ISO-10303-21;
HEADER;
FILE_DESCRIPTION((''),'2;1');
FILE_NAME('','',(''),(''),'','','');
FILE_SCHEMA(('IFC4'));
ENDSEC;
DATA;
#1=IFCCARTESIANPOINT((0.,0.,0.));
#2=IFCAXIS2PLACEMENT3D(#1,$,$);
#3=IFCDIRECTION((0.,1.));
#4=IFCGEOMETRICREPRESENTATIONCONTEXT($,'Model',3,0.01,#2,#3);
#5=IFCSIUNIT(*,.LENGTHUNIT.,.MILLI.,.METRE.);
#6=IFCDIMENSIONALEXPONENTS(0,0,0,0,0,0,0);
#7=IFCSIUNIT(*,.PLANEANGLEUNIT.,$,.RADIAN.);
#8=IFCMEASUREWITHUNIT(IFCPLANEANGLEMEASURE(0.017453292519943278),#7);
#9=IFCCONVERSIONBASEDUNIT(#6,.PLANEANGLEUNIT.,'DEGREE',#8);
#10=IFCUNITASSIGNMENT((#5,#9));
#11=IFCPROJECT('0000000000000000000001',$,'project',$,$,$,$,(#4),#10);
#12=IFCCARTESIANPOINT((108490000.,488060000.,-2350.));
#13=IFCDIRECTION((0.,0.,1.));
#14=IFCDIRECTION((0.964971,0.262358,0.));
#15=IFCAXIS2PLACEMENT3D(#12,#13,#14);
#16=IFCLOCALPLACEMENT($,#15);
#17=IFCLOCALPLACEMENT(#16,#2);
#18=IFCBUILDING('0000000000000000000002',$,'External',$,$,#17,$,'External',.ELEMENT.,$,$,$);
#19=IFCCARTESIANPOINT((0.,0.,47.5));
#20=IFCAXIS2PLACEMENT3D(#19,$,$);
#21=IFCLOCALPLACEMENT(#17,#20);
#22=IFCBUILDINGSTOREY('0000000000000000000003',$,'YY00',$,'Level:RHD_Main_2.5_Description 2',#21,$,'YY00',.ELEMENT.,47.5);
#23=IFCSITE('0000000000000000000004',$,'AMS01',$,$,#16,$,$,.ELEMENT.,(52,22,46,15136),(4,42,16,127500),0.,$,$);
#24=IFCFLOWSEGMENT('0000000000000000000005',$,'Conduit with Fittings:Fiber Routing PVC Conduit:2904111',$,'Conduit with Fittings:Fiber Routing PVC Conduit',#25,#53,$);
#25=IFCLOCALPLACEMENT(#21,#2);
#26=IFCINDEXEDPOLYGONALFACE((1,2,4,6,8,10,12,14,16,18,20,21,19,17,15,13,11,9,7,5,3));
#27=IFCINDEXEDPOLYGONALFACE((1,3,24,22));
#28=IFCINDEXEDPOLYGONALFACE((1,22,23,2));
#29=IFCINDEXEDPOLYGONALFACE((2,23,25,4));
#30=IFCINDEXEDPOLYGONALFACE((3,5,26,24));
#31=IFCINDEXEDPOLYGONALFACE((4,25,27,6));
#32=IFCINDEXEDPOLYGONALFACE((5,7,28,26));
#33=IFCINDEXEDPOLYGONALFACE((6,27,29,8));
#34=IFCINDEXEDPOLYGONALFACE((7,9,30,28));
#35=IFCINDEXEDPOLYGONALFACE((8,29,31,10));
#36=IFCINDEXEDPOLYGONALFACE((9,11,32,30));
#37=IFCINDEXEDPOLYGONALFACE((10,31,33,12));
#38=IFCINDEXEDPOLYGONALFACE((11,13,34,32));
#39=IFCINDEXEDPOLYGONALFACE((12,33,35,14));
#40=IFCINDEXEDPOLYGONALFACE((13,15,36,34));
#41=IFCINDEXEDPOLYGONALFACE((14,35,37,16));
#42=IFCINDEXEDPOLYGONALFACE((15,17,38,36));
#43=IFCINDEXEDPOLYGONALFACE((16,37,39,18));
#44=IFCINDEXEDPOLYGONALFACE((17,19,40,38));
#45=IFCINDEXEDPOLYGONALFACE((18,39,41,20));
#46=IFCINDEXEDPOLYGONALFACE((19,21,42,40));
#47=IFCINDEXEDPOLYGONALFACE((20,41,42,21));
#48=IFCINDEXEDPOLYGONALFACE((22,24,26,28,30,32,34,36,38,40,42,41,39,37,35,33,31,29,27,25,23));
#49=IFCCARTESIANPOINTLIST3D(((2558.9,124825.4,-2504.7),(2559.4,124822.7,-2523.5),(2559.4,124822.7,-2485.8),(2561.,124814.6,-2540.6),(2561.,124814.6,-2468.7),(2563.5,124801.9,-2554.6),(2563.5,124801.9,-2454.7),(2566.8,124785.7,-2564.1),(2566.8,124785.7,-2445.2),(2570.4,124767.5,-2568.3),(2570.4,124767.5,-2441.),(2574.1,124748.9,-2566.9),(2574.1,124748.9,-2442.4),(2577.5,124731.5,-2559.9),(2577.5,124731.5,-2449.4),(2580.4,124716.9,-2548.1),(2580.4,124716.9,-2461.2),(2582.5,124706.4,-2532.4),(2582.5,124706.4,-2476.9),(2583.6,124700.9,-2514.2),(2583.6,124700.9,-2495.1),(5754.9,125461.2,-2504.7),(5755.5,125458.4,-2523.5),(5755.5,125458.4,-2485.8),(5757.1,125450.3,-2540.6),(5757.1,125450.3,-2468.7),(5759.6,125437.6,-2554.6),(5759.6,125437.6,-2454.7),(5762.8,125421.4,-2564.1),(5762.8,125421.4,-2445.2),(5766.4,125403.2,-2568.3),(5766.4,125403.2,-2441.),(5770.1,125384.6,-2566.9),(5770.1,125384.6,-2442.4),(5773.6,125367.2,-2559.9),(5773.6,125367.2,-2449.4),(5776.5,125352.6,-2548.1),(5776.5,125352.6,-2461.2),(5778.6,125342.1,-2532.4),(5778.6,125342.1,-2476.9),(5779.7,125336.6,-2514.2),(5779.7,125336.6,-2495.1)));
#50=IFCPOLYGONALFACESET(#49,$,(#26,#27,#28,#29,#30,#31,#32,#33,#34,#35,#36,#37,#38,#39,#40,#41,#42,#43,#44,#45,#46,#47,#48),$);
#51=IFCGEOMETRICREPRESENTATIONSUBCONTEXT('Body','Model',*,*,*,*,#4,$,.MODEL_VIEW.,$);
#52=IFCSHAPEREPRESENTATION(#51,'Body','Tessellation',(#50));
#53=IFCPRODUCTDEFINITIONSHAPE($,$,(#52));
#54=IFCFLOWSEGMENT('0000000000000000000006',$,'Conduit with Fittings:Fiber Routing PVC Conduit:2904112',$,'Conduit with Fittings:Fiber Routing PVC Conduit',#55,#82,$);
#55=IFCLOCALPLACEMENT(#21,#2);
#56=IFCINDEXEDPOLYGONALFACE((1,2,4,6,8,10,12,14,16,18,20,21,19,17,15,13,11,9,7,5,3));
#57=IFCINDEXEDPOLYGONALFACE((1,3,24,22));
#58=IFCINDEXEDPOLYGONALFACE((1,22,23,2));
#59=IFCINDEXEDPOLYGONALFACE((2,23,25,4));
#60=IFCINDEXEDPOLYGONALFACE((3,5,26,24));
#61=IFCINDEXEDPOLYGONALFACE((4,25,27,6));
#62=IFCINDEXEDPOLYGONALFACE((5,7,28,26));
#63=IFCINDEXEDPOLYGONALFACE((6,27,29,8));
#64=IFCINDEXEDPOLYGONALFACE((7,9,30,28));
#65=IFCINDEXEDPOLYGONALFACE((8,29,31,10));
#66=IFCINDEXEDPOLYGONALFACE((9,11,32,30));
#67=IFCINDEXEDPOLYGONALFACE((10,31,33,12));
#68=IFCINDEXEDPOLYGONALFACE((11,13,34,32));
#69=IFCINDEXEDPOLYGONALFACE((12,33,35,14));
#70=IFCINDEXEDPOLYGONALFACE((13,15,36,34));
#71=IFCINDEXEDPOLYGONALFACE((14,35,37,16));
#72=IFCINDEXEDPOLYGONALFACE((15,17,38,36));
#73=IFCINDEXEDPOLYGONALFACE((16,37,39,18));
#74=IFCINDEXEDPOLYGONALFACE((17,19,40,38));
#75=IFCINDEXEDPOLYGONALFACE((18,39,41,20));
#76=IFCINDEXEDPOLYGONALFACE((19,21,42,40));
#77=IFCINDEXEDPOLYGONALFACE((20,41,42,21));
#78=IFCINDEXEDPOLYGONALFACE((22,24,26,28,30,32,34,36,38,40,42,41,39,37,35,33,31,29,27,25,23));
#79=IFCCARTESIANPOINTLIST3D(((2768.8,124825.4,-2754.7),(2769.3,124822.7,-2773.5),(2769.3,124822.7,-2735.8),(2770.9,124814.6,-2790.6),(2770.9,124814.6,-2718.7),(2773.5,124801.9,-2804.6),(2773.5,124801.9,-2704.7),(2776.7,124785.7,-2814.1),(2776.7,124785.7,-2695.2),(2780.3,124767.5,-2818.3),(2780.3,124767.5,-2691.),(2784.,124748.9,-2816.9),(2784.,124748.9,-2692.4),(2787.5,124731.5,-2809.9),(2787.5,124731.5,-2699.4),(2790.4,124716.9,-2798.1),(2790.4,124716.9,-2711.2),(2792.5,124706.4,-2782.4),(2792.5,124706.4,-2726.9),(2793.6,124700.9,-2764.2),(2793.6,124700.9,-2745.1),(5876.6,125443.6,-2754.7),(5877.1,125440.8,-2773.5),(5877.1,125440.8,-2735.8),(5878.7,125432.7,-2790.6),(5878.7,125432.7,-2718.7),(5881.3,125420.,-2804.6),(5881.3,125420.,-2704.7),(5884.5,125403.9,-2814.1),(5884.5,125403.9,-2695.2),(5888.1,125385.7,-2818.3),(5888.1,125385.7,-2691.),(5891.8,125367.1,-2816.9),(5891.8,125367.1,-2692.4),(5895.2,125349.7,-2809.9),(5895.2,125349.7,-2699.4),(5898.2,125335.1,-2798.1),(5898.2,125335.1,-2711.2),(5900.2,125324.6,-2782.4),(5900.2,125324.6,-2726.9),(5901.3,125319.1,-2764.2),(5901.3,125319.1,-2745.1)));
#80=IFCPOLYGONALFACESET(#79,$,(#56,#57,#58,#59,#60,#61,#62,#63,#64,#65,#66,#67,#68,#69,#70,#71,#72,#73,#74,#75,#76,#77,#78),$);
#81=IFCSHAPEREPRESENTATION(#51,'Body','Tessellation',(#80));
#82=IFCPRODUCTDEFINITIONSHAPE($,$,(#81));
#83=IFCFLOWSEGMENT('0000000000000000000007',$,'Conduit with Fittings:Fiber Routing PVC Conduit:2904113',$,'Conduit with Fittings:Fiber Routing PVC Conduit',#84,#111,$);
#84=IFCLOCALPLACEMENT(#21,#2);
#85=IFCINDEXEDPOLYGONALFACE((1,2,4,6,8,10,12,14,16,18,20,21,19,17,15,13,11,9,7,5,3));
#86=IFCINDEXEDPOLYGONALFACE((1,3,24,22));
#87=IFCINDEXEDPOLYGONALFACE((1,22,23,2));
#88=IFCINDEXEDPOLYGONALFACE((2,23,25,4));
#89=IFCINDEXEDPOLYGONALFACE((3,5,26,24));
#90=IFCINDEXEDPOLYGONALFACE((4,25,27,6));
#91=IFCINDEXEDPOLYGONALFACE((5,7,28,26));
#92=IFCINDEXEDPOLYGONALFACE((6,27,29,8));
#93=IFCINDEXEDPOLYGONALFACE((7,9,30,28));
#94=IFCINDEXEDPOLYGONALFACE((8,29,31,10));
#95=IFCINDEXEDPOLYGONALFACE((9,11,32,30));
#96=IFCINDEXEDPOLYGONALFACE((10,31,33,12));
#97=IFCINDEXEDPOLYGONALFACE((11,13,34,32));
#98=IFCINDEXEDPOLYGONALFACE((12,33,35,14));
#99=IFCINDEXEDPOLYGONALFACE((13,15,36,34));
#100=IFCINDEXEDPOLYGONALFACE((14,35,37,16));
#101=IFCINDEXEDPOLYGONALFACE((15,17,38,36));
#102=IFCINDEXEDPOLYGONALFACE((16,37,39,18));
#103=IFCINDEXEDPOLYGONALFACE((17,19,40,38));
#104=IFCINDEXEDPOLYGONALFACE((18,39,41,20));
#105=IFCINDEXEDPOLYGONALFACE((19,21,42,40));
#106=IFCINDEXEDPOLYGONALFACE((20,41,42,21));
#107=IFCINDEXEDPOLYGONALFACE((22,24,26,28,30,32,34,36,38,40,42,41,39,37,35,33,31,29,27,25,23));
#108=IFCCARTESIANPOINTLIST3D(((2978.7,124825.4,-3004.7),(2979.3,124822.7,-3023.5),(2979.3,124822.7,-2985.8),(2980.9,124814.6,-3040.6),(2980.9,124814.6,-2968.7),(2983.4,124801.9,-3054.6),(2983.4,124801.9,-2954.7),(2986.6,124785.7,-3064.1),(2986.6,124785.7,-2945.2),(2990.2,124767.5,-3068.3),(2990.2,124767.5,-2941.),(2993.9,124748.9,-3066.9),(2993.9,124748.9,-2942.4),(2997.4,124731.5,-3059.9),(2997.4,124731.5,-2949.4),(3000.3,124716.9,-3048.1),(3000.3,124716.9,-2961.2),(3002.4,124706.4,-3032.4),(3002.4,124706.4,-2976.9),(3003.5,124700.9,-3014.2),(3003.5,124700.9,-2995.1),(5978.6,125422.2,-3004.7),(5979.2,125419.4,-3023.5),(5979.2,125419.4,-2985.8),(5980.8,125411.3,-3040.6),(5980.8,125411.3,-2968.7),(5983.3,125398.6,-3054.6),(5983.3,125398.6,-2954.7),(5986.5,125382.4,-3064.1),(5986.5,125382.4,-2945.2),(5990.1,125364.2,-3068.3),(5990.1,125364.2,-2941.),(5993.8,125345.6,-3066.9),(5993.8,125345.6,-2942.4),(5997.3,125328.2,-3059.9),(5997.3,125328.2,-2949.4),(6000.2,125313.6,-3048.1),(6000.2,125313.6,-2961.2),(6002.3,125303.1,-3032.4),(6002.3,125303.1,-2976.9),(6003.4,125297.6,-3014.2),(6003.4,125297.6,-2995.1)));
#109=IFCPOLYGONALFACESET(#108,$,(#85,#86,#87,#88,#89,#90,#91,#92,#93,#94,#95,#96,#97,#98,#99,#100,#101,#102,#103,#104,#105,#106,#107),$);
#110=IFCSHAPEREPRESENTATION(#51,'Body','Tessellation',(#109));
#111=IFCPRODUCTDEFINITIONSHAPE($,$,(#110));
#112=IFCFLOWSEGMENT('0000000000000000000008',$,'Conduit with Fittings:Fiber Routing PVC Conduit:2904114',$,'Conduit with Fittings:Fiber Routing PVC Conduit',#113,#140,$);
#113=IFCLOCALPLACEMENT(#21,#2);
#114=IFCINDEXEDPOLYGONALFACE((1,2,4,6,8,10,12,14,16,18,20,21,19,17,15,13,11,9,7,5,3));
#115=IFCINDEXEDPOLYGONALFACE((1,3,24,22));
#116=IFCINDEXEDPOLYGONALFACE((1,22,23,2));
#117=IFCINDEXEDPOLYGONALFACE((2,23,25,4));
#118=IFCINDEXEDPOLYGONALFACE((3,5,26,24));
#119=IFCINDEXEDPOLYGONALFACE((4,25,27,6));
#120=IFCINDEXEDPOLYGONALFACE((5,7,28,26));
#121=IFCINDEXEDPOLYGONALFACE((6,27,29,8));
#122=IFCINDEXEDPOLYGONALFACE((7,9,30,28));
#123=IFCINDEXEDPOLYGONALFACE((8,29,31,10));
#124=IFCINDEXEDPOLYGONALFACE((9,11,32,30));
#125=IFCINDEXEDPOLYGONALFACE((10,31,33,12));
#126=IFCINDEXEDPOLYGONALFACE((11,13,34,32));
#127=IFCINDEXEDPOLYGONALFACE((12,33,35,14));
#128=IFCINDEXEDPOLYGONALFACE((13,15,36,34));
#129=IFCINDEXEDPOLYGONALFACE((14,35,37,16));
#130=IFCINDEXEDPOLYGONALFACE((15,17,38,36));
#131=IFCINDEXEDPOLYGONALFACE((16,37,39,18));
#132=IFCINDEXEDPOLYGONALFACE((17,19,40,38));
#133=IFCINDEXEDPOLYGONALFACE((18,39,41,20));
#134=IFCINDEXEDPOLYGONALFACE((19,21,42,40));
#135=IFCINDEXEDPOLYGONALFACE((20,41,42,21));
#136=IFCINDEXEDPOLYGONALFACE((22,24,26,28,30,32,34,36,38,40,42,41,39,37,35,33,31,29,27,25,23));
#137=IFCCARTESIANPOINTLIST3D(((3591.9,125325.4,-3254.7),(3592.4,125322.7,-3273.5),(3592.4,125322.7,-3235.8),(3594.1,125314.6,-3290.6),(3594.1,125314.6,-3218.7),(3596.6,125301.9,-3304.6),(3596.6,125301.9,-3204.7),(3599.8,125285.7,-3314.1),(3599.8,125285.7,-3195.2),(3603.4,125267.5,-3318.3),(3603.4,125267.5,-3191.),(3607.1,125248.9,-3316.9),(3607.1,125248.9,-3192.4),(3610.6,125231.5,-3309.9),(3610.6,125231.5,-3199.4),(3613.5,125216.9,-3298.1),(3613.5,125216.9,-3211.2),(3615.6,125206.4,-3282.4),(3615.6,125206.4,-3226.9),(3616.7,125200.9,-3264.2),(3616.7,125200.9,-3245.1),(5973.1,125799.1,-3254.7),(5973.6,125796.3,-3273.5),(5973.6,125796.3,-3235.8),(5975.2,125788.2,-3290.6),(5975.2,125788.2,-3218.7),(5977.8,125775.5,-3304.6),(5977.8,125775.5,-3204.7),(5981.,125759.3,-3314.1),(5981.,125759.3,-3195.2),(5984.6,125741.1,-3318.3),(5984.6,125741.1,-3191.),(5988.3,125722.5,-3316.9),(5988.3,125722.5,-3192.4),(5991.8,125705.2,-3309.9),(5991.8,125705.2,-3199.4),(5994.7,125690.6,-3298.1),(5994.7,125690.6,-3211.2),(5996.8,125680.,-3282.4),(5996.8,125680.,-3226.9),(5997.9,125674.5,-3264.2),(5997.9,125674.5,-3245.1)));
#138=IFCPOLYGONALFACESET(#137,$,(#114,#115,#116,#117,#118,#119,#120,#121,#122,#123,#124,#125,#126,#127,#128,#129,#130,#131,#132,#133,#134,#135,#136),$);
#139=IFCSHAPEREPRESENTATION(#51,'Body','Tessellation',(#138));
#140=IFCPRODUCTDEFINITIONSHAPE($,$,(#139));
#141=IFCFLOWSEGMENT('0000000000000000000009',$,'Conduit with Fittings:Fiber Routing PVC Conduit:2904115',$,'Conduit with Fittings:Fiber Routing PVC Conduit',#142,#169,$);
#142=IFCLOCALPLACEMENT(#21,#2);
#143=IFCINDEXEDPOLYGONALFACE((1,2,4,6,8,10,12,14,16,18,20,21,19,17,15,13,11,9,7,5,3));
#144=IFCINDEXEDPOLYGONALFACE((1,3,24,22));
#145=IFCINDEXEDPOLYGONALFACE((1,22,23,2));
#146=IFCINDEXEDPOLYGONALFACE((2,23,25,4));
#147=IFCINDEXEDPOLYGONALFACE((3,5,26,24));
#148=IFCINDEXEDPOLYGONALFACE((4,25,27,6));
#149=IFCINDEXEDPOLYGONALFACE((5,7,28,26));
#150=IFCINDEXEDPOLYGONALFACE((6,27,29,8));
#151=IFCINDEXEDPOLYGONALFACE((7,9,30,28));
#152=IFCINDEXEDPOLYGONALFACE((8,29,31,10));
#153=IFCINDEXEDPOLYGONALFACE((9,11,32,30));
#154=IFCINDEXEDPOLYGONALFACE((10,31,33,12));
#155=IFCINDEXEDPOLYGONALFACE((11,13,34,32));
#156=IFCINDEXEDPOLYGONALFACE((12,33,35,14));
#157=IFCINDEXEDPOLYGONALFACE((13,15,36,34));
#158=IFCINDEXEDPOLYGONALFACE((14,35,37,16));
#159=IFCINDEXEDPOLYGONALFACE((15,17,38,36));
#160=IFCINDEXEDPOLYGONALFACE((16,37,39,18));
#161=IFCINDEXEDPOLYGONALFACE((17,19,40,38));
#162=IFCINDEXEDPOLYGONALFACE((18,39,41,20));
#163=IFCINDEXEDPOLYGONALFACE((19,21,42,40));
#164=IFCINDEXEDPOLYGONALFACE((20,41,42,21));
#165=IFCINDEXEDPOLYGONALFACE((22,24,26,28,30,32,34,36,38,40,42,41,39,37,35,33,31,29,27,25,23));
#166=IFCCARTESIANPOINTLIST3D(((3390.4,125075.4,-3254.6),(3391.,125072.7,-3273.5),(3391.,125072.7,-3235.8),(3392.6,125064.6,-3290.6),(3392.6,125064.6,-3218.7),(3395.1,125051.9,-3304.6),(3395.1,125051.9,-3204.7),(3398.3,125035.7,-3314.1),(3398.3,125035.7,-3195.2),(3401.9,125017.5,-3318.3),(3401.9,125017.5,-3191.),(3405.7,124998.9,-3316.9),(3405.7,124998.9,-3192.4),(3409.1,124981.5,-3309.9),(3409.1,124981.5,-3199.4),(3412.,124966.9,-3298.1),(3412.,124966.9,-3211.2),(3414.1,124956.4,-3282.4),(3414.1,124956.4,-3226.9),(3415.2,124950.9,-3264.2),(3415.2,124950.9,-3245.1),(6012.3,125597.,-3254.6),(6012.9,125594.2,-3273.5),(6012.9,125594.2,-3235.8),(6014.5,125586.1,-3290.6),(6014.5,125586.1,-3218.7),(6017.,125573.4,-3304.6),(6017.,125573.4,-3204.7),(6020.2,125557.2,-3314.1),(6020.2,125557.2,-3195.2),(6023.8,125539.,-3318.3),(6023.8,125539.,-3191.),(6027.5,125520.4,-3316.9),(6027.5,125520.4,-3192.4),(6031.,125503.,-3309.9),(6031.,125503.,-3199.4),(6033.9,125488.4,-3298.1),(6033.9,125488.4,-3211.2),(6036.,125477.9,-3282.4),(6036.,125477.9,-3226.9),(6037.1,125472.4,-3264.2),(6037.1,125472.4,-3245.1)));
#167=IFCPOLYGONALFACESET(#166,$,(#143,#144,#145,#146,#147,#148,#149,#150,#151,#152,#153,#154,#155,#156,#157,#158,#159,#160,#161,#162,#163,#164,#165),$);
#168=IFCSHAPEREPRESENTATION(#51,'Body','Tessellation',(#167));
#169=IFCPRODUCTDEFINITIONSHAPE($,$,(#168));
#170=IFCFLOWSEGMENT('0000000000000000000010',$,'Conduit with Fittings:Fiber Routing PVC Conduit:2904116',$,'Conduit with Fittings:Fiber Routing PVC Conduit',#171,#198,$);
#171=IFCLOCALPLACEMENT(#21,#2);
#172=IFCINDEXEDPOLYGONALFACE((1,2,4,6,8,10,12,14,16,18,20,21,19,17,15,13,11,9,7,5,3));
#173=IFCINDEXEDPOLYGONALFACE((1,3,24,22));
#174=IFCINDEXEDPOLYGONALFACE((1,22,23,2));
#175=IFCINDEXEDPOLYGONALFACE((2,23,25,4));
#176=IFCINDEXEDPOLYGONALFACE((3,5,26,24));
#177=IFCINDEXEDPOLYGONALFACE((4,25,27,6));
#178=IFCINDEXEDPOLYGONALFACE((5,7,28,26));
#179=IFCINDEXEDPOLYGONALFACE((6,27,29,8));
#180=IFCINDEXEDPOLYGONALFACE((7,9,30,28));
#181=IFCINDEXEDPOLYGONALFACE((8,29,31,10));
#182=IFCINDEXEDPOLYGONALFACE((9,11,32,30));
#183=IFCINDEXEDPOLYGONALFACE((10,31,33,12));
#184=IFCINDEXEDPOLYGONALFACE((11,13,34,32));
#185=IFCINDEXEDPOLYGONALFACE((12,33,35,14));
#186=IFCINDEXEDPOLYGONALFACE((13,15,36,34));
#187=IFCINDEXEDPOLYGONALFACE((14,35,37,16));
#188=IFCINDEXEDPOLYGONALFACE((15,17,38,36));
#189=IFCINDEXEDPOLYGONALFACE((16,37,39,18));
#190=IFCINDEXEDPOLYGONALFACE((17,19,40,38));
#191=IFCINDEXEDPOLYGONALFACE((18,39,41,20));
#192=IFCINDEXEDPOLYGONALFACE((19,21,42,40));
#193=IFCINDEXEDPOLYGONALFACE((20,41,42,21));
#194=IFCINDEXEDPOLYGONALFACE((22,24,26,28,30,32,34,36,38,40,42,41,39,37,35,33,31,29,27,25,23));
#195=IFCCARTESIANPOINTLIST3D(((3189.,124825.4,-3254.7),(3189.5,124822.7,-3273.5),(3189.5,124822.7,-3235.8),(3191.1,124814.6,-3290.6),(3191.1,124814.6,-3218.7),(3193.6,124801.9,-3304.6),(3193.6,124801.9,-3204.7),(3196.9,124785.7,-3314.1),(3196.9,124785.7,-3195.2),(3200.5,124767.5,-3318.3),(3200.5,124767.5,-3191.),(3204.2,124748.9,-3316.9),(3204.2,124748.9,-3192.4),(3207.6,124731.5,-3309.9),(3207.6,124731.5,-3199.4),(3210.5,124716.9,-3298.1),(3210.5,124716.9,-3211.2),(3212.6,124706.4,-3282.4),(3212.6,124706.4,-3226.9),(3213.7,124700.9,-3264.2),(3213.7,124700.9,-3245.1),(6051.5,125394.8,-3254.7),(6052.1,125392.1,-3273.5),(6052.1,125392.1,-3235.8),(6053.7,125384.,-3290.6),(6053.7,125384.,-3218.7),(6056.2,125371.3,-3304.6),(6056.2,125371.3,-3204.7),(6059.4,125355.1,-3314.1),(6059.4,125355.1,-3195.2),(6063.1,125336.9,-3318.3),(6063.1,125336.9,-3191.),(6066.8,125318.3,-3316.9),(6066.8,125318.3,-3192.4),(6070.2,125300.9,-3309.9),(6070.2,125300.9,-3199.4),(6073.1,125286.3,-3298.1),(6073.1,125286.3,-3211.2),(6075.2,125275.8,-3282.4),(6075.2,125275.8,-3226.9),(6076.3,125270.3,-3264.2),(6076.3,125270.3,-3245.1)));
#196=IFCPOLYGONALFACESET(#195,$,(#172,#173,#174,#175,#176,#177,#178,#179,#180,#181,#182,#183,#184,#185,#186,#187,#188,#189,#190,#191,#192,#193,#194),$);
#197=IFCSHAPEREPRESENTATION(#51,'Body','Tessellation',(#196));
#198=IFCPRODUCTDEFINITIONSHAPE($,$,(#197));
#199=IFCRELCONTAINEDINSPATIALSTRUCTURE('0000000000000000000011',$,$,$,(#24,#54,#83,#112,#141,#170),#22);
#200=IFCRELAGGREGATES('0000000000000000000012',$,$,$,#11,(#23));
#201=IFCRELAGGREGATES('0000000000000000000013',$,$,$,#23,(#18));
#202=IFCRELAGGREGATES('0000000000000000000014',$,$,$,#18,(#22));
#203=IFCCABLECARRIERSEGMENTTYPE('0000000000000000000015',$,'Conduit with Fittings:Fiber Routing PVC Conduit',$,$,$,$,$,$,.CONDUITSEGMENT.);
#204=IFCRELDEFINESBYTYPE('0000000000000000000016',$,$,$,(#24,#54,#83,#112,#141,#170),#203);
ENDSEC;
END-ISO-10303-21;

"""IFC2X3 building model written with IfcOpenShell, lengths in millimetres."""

from ifc_helpers import new_model, entity, si_unit, converted_unit, direction, frame, frame_2d, origin, place, context, subcontext, project, spatial, circle, extrude, type_object, element, save


model = new_model("IFC2X3")

# Units and contexts
model_context = context("Model", 3, precision=0.01, world=origin(), true_north=direction((0.0, 1.0)))
body_context = subcontext(model_context, "Body", "Model", "MODEL_VIEW")
ifc_project = project(units=[si_unit("LENGTHUNIT", "METRE", prefix="MILLI"), converted_unit("PLANEANGLEUNIT", "DEGREE", entity("IfcPlaneAngleMeasure", 0.017453292519943278), si_unit("PLANEANGLEUNIT", "RADIAN"), dimensions=[0, 0, 0, 0, 0, 0, 0])], contexts=[model_context])

# Site, building, storey
site_placement = place(None, frame((108490000.0, 488060000.0, -2350.0), z_axis=(0.0, 0.0, 1.0), x_axis=(0.964971, 0.262358, 0.0)))
site = spatial("IfcSite", under=ifc_project, at=site_placement, Name="AMS01", CompositionType="ELEMENT", RefLatitude=(52, 22, 46, 15136), RefLongitude=(4, 42, 16, 127500), RefElevation=0.0)
building_placement = place(site_placement, origin())
building = spatial("IfcBuilding", under=site, at=building_placement, Name="External", LongName="External", CompositionType="ELEMENT")
storey_placement = place(building_placement, frame((0.0, 0.0, 47.5)))
storey = spatial("IfcBuildingStorey", under=building, at=storey_placement, Name="YY00", ObjectType="Level:RHD_Main_2.5_Description 2", LongName="YY00", CompositionType="ELEMENT", Elevation=47.5)

# Flow segments
cable_carrier_segment_type = type_object("IfcCableCarrierSegmentType", Name="Conduit with Fittings:Fiber Routing PVC Conduit", PredefinedType="CONDUITSEGMENT")
flow_segment_1_placement = place(storey_placement, origin())
element("IfcFlowSegment", 1, at=flow_segment_1_placement, inside=storey, type_object=cable_carrier_segment_type, Name="Conduit with Fittings:Fiber Routing PVC Conduit:2904111", ObjectType="Conduit with Fittings:Fiber Routing PVC Conduit", context=body_context, shape_type="SweptSolid", body=[
    extrude(circle(Radius=63.9, at=frame_2d((0.0, 0.0), x_axis=(1.0, 0.0))), frame((2571.3, 124762.8, -2504.7), z_axis=(0.980785, 0.19509, 0.0), x_axis=(-0.19509, 0.980785, 0.0)), (0.0, 0.0, 1.0), 3258.7),
])
flow_segment_2_placement = place(storey_placement, origin())
element("IfcFlowSegment", 2, at=flow_segment_2_placement, inside=storey, type_object=cable_carrier_segment_type, Name="Conduit with Fittings:Fiber Routing PVC Conduit:2904112", ObjectType="Conduit with Fittings:Fiber Routing PVC Conduit", context=body_context, shape_type="SweptSolid", body=[
    extrude(circle(Radius=63.9, at=frame_2d((0.0, 0.0), x_axis=(1.0, 0.0))), frame((2781.2, 124762.8, -2754.7), z_axis=(0.980785, 0.19509, 0.0), x_axis=(-0.19509, 0.980785, 0.0)), (0.0, 0.0, 1.0), 3168.7),
])
flow_segment_3_placement = place(storey_placement, origin())
element("IfcFlowSegment", 3, at=flow_segment_3_placement, inside=storey, type_object=cable_carrier_segment_type, Name="Conduit with Fittings:Fiber Routing PVC Conduit:2904113", ObjectType="Conduit with Fittings:Fiber Routing PVC Conduit", context=body_context, shape_type="SweptSolid", body=[
    extrude(circle(Radius=63.9, at=frame_2d((0.0, 0.0), x_axis=(1.0, 0.0))), frame((2991.2, 124762.8, -3004.7), z_axis=(0.980785, 0.19509, 0.0), x_axis=(-0.19509, 0.980785, 0.0)), (0.0, 0.0, 1.0), 3058.7),
])
flow_segment_4_placement = place(storey_placement, origin())
element("IfcFlowSegment", 4, at=flow_segment_4_placement, inside=storey, type_object=cable_carrier_segment_type, Name="Conduit with Fittings:Fiber Routing PVC Conduit:2904114", ObjectType="Conduit with Fittings:Fiber Routing PVC Conduit", context=body_context, shape_type="SweptSolid", body=[
    extrude(circle(Radius=63.9, at=frame_2d((0.0, 0.0), x_axis=(1.0, 0.0))), frame((3604.4, 125262.8, -3254.7), z_axis=(0.980785, 0.19509, 0.0), x_axis=(-0.19509, 0.980785, 0.0)), (0.0, 0.0, 1.0), 2427.8),
])
flow_segment_5_placement = place(storey_placement, origin())
element("IfcFlowSegment", 5, at=flow_segment_5_placement, inside=storey, type_object=cable_carrier_segment_type, Name="Conduit with Fittings:Fiber Routing PVC Conduit:2904115", ObjectType="Conduit with Fittings:Fiber Routing PVC Conduit", context=body_context, shape_type="SweptSolid", body=[
    extrude(circle(Radius=63.9, at=frame_2d((0.0, 0.0), x_axis=(1.0, 0.0))), frame((3402.9, 125012.8, -3254.6), z_axis=(0.980785, 0.19509, 0.0), x_axis=(-0.19509, 0.980785, 0.0)), (0.0, 0.0, 1.0), 2673.3),
])
flow_segment_6_placement = place(storey_placement, origin())
element("IfcFlowSegment", 6, at=flow_segment_6_placement, inside=storey, type_object=cable_carrier_segment_type, Name="Conduit with Fittings:Fiber Routing PVC Conduit:2904116", ObjectType="Conduit with Fittings:Fiber Routing PVC Conduit", context=body_context, shape_type="SweptSolid", body=[
    extrude(circle(Radius=63.9, at=frame_2d((0.0, 0.0), x_axis=(1.0, 0.0))), frame((3201.4, 124762.8, -3254.7), z_axis=(0.980785, 0.19509, 0.0), x_axis=(-0.19509, 0.980785, 0.0)), (0.0, 0.0, 1.0), 2918.7),
])

save(model, "model.ifc")
